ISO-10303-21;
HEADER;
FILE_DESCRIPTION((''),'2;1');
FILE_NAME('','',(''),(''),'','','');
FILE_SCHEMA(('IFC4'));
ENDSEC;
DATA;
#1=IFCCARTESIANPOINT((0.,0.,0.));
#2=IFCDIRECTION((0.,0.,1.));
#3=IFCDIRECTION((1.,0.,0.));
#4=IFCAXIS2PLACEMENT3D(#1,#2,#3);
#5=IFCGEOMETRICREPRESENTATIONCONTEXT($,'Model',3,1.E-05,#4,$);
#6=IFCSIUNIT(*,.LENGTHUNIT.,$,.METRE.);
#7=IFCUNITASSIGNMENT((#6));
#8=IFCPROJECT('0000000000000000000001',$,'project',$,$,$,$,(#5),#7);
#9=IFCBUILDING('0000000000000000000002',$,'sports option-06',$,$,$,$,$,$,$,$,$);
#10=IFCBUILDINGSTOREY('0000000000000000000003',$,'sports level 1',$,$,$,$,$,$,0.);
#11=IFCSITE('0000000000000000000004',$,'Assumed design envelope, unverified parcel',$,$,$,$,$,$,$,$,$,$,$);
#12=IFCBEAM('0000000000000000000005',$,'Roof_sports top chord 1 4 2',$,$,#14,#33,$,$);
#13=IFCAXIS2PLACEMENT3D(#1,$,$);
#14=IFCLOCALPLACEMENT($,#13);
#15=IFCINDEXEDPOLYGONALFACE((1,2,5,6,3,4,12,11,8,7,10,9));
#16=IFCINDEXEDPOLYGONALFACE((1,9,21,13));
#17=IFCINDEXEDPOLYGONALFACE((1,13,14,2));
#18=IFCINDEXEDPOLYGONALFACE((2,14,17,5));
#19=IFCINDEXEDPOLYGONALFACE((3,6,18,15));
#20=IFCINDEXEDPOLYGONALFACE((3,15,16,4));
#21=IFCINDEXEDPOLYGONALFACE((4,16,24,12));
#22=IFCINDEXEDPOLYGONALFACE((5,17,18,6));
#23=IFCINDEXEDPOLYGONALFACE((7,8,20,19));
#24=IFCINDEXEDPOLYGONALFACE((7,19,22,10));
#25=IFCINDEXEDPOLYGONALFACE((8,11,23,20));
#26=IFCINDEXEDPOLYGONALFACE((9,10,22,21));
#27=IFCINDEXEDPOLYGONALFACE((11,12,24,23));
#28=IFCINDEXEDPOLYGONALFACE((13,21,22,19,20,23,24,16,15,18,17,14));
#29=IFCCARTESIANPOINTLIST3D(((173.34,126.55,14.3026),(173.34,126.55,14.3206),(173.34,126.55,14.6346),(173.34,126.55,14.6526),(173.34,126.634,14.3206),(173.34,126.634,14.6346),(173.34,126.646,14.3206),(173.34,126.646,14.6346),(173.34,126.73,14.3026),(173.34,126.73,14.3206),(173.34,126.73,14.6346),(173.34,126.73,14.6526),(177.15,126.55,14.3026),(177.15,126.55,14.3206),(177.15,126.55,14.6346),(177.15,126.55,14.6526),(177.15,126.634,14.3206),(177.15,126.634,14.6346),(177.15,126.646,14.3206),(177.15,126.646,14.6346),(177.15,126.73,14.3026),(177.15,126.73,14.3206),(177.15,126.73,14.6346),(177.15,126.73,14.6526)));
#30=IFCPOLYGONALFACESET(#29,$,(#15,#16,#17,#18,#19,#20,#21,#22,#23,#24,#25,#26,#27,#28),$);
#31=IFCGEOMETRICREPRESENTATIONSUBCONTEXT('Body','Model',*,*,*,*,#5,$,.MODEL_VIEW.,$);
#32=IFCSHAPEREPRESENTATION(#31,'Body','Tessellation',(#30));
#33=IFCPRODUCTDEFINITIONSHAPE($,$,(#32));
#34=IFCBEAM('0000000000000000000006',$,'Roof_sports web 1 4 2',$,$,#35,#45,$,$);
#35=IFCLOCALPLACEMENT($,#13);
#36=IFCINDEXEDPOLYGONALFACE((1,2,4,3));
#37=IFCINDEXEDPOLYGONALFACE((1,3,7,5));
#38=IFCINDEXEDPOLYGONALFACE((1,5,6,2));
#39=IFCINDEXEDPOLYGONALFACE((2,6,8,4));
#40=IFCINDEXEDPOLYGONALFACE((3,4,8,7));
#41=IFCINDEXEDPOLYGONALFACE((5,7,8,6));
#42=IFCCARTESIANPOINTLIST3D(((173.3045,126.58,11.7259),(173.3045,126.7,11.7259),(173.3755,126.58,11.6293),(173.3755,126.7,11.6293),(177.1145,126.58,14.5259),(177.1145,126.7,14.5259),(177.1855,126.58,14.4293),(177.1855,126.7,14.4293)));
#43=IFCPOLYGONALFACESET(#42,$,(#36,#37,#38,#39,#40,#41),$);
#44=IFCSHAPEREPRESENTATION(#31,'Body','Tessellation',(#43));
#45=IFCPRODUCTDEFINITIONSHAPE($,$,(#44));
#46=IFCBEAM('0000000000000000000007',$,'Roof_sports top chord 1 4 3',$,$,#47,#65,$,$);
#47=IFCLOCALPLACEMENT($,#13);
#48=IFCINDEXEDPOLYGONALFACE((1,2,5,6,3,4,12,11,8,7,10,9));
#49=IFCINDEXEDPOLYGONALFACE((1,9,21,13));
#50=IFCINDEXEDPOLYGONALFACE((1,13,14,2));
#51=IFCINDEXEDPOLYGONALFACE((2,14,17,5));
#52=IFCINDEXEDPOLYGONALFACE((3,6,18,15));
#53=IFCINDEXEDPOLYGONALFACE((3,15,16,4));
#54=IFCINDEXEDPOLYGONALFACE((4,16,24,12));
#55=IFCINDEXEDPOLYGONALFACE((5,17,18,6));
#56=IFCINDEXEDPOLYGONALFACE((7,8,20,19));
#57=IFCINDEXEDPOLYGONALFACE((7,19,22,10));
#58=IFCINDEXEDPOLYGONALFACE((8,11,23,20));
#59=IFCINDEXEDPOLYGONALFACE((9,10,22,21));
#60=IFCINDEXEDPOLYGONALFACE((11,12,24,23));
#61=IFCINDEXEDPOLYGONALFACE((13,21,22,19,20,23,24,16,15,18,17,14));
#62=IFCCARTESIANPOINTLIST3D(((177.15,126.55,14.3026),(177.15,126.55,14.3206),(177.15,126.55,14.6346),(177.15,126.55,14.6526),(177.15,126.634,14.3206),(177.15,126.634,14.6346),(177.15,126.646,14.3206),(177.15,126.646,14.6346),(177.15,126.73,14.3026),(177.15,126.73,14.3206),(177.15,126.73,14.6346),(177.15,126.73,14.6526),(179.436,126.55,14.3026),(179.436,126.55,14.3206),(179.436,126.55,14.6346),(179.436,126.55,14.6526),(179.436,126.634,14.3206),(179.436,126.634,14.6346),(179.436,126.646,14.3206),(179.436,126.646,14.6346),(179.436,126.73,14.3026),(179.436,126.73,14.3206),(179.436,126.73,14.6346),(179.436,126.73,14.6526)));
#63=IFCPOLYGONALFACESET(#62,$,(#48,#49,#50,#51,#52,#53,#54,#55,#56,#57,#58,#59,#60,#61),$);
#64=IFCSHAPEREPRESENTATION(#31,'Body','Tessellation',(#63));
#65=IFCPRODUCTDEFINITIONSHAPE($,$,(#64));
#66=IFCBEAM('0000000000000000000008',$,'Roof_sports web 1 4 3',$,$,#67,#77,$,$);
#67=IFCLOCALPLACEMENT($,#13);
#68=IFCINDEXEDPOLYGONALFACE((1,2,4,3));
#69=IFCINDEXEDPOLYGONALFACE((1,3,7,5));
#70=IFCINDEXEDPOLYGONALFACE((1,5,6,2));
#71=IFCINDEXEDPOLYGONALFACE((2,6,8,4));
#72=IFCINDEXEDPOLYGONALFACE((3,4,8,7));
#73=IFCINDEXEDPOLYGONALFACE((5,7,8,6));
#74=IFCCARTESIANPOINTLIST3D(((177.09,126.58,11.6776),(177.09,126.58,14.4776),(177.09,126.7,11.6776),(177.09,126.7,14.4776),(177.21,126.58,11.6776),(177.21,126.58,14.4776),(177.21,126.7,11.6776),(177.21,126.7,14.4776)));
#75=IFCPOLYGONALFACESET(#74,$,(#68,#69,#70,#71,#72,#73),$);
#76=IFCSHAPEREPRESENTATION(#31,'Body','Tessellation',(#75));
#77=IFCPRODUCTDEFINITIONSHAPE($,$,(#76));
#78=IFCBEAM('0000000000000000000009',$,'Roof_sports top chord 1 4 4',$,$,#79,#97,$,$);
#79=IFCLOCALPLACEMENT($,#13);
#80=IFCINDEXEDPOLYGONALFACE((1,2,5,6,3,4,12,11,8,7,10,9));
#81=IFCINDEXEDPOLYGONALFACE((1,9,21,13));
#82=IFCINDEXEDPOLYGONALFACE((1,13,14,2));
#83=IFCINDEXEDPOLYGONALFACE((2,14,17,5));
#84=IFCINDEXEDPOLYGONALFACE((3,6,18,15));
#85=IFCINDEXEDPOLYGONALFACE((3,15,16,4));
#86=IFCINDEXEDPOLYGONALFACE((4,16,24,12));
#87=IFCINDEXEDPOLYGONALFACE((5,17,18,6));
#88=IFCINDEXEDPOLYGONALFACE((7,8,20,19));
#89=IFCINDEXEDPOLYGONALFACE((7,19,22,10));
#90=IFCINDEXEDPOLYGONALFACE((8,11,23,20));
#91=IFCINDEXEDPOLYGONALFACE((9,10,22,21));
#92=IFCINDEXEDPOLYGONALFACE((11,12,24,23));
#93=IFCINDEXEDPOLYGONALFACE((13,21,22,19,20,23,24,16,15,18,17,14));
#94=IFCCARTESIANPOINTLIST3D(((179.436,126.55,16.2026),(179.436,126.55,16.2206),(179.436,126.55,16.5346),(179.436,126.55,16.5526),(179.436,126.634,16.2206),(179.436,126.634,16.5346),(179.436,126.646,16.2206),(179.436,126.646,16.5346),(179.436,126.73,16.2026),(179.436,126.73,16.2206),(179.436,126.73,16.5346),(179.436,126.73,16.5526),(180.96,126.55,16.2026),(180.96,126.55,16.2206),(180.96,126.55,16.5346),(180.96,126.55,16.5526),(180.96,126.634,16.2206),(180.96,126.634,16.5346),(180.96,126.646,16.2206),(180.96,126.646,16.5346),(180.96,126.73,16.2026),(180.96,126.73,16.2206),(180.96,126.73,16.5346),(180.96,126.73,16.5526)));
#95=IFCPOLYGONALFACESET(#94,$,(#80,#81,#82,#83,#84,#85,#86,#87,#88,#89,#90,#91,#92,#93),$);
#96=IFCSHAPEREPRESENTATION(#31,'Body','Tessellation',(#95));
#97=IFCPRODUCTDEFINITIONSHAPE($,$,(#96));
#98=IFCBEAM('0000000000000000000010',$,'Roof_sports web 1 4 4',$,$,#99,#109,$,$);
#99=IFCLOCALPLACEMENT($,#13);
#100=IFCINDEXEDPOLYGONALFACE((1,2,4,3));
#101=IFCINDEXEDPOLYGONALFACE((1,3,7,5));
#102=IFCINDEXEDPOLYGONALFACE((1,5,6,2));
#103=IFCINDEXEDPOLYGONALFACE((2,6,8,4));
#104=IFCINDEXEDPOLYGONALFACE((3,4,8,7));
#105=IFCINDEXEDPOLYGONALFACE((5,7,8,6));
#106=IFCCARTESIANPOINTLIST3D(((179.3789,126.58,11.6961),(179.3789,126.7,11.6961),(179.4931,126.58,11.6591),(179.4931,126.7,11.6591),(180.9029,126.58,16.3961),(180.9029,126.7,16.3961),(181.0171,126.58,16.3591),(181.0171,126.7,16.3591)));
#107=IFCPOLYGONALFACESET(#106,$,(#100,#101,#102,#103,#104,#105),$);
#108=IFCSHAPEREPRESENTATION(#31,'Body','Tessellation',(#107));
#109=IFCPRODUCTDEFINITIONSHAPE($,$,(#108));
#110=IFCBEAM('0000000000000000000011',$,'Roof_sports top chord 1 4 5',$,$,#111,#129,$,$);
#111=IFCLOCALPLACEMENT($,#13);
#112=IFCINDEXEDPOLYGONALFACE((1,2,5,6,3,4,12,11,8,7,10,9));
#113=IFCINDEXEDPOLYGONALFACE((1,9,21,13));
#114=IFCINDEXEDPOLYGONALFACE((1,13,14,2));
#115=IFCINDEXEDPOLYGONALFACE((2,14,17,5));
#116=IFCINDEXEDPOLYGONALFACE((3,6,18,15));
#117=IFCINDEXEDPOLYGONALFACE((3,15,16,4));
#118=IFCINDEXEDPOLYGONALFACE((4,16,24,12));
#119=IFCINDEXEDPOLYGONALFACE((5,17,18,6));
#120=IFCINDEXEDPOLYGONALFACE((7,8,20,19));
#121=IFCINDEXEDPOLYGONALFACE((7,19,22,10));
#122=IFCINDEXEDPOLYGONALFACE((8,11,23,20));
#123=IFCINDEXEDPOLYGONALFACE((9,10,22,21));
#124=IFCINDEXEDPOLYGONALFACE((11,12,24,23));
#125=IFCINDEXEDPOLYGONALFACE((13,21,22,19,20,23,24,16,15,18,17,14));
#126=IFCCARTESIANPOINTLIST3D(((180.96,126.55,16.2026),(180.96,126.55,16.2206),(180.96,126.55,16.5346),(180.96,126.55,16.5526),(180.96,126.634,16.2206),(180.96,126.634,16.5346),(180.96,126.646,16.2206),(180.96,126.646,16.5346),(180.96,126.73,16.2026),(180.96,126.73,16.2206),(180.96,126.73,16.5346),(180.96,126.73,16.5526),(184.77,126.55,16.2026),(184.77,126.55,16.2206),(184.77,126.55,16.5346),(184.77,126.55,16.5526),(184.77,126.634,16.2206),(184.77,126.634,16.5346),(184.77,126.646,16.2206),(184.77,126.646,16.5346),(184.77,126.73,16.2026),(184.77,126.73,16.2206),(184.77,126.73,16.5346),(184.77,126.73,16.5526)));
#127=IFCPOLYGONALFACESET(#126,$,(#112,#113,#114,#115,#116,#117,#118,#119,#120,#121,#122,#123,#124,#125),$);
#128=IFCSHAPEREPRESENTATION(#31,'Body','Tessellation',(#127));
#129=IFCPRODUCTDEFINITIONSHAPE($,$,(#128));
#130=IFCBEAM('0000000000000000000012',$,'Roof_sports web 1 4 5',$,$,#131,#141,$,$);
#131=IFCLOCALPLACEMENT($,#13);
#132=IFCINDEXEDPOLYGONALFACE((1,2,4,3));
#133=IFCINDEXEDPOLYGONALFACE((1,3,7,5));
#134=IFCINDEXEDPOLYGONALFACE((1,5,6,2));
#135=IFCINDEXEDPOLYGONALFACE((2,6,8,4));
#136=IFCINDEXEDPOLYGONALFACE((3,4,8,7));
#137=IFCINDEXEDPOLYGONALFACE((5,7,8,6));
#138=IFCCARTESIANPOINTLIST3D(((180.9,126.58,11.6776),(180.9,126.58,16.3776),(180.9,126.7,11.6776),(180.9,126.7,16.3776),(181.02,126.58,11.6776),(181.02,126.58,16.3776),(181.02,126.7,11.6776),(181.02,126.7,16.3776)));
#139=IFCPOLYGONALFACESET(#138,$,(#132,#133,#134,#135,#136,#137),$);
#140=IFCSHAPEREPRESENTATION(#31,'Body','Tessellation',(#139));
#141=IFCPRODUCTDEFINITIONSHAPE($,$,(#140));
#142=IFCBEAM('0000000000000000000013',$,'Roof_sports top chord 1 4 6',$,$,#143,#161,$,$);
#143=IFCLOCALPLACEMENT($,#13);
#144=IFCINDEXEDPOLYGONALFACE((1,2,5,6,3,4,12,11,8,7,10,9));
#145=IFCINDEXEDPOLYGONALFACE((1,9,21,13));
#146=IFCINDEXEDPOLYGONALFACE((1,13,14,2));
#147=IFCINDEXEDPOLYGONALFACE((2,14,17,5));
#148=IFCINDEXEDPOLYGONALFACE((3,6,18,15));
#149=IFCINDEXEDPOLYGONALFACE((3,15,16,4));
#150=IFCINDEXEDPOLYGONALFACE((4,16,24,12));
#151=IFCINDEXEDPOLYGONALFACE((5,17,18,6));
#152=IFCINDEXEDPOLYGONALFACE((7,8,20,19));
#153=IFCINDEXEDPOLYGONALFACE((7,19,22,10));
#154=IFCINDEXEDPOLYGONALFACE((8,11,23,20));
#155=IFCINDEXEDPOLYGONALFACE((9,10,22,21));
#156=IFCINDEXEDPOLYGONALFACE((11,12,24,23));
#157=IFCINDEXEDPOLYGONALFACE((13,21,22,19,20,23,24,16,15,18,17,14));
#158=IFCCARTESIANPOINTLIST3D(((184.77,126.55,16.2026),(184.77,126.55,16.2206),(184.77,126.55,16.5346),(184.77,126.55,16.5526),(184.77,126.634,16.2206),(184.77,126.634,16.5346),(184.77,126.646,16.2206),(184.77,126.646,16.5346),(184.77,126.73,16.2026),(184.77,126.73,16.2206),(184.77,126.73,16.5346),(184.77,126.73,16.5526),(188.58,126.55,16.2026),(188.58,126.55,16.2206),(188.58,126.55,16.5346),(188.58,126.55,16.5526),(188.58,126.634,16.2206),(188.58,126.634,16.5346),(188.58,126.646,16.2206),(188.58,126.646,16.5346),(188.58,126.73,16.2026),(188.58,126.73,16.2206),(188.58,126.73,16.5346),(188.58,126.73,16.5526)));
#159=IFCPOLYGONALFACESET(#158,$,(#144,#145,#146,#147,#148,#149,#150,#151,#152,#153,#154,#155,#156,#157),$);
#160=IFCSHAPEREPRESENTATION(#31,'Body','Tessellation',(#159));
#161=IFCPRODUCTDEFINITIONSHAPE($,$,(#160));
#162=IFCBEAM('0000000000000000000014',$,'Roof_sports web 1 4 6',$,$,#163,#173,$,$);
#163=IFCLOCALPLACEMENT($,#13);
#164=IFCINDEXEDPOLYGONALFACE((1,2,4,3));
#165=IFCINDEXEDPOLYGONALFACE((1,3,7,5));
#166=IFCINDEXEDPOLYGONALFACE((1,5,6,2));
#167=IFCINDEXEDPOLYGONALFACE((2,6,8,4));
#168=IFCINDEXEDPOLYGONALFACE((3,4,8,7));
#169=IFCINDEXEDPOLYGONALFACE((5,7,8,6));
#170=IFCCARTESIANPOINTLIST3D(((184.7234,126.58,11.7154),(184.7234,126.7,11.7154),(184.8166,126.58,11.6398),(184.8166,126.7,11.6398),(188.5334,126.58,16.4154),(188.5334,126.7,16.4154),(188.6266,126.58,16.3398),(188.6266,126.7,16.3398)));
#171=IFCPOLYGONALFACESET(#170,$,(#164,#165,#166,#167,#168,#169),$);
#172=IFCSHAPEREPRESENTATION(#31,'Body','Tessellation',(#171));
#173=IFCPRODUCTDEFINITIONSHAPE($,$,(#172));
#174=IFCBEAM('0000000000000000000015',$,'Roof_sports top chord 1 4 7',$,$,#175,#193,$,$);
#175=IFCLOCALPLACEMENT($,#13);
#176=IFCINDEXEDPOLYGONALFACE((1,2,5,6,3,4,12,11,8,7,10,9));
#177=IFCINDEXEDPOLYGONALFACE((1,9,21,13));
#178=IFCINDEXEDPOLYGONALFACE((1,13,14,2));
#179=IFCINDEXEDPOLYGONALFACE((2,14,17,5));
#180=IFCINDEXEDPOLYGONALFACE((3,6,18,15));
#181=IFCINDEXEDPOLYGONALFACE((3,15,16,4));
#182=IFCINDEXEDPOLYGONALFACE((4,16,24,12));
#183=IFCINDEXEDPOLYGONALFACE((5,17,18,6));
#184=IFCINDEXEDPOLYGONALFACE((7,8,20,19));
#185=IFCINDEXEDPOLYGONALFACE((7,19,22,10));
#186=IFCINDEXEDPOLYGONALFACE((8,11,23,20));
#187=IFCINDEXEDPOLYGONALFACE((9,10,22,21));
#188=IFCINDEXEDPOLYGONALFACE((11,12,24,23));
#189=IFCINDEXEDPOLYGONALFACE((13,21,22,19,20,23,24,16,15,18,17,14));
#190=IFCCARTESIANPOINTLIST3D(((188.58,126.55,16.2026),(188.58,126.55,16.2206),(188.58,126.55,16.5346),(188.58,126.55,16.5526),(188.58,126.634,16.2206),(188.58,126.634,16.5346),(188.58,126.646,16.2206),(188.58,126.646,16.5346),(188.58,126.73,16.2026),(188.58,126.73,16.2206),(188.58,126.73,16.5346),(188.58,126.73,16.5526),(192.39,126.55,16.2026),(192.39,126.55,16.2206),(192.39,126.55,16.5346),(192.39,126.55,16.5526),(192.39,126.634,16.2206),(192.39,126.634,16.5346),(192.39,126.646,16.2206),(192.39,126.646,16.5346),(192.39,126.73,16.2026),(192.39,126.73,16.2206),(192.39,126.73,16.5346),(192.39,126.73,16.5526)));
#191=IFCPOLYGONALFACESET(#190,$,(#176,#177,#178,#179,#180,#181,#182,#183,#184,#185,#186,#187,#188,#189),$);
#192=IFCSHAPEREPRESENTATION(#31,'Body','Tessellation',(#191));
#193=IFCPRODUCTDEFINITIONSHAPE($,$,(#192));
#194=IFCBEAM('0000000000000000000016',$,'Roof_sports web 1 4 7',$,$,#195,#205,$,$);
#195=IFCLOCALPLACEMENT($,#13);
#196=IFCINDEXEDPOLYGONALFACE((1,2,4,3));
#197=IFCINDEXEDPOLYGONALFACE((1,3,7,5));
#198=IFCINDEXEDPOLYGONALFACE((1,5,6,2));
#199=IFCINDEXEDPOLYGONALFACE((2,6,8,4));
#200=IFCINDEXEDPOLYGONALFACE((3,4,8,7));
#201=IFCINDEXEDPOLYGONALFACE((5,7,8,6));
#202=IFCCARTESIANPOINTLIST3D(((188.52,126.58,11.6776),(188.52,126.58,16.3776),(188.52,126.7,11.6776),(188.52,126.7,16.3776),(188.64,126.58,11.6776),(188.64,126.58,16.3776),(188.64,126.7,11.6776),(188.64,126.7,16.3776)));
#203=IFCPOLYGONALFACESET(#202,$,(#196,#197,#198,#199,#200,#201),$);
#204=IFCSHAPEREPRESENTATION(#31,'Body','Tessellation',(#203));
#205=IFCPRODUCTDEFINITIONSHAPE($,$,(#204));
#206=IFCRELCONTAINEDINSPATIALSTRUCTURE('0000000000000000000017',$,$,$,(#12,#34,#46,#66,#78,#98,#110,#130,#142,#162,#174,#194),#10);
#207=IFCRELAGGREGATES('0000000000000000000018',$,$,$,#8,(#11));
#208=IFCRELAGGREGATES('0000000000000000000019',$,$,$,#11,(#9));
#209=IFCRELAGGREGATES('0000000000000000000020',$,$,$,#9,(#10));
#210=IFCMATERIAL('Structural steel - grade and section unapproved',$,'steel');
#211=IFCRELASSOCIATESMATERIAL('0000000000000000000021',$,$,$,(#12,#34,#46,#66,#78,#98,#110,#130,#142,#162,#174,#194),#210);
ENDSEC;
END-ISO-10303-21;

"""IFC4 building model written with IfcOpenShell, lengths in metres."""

from ifc_helpers import new_model, si_unit, frame, origin_with_axes, place, context, subcontext, project, spatial, rectangle, i_section, extrude, material, element, save


model = new_model("IFC4")

# Units and contexts
model_context = context("Model", 3, precision=1e-05, world=origin_with_axes())
body_context = subcontext(model_context, "Body", "Model", "MODEL_VIEW")
ifc_project = project(units=[si_unit("LENGTHUNIT", "METRE")], contexts=[model_context])

# Site, building, storey
site = spatial("IfcSite", under=ifc_project, Name="Assumed design envelope, unverified parcel")
building = spatial("IfcBuilding", under=site, Name="sports option-06")
storey = spatial("IfcBuildingStorey", under=building, Name="sports level 1", Elevation=0.0)

# Shared definitions
ifc_material_1 = material(Name="Structural steel - grade and section unapproved", Category="steel")

# Beams
beam_1_placement = place(None, frame((173.34, 126.64, 14.4776), z_axis=(1.0, 0.0, 0.0), x_axis=(0.0, 1.0, 0.0)))
element("IfcBeam", 1, at=beam_1_placement, inside=storey, material=ifc_material_1, Name="Roof_sports top chord 1 4 2", context=body_context, shape_type="SweptSolid", body=[
    extrude(i_section(OverallWidth=0.18, OverallDepth=0.35, WebThickness=0.012, FlangeThickness=0.018, FilletRadius=0.0), origin_with_axes(), (0.0, 0.0, 1.0), 3.81),
])
beam_2_placement = place(None, frame((173.34, 126.64, 11.6776), z_axis=(0.805799, 0.0, 0.592189), x_axis=(0.0, 1.0, 0.0)))
element("IfcBeam", 2, at=beam_2_placement, inside=storey, material=ifc_material_1, Name="Roof_sports web 1 4 2", context=body_context, shape_type="SweptSolid", body=[
    extrude(rectangle(XDim=0.12, YDim=0.12), origin_with_axes(), (0.0, 0.0, 1.0), 4.7282),
])
beam_3_placement = place(None, frame((177.15, 126.64, 14.4776), z_axis=(1.0, 0.0, 0.0), x_axis=(0.0, 1.0, 0.0)))
element("IfcBeam", 3, at=beam_3_placement, inside=storey, material=ifc_material_1, Name="Roof_sports top chord 1 4 3", context=body_context, shape_type="SweptSolid", body=[
    extrude(i_section(OverallWidth=0.18, OverallDepth=0.35, WebThickness=0.012, FlangeThickness=0.018, FilletRadius=0.0), origin_with_axes(), (0.0, 0.0, 1.0), 2.286),
])
beam_4_placement = place(None, frame((177.15, 126.64, 11.6776), z_axis=(0.0, 0.0, 1.0), x_axis=(-1.0, 0.0, 0.0)))
element("IfcBeam", 4, at=beam_4_placement, inside=storey, material=ifc_material_1, Name="Roof_sports web 1 4 3", context=body_context, shape_type="SweptSolid", body=[
    extrude(rectangle(XDim=0.12, YDim=0.12), origin_with_axes(), (0.0, 0.0, 1.0), 2.8),
])
beam_5_placement = place(None, frame((179.436, 126.64, 16.3776), z_axis=(1.0, 0.0, 0.0), x_axis=(0.0, 1.0, 0.0)))
element("IfcBeam", 5, at=beam_5_placement, inside=storey, material=ifc_material_1, Name="Roof_sports top chord 1 4 4", context=body_context, shape_type="SweptSolid", body=[
    extrude(i_section(OverallWidth=0.18, OverallDepth=0.35, WebThickness=0.012, FlangeThickness=0.018, FilletRadius=0.0), origin_with_axes(), (0.0, 0.0, 1.0), 1.524),
])
beam_6_placement = place(None, frame((179.436, 126.64, 11.6776), z_axis=(0.308446, 0.0, 0.951242), x_axis=(0.0, 1.0, 0.0)))
element("IfcBeam", 6, at=beam_6_placement, inside=storey, material=ifc_material_1, Name="Roof_sports web 1 4 4", context=body_context, shape_type="SweptSolid", body=[
    extrude(rectangle(XDim=0.12, YDim=0.12), origin_with_axes(), (0.0, 0.0, 1.0), 4.9409),
])
beam_7_placement = place(None, frame((180.96, 126.64, 16.3776), z_axis=(1.0, 0.0, 0.0), x_axis=(0.0, 1.0, 0.0)))
element("IfcBeam", 7, at=beam_7_placement, inside=storey, material=ifc_material_1, Name="Roof_sports top chord 1 4 5", context=body_context, shape_type="SweptSolid", body=[
    extrude(i_section(OverallWidth=0.18, OverallDepth=0.35, WebThickness=0.012, FlangeThickness=0.018, FilletRadius=0.0), origin_with_axes(), (0.0, 0.0, 1.0), 3.81),
])
beam_8_placement = place(None, frame((180.96, 126.64, 11.6776), z_axis=(0.0, 0.0, 1.0), x_axis=(-1.0, 0.0, 0.0)))
element("IfcBeam", 8, at=beam_8_placement, inside=storey, material=ifc_material_1, Name="Roof_sports web 1 4 5", context=body_context, shape_type="SweptSolid", body=[
    extrude(rectangle(XDim=0.12, YDim=0.12), origin_with_axes(), (0.0, 0.0, 1.0), 4.7),
])
beam_9_placement = place(None, frame((184.77, 126.64, 16.3776), z_axis=(1.0, 0.0, 0.0), x_axis=(0.0, 1.0, 0.0)))
element("IfcBeam", 9, at=beam_9_placement, inside=storey, material=ifc_material_1, Name="Roof_sports top chord 1 4 6", context=body_context, shape_type="SweptSolid", body=[
    extrude(i_section(OverallWidth=0.18, OverallDepth=0.35, WebThickness=0.012, FlangeThickness=0.018, FilletRadius=0.0), origin_with_axes(), (0.0, 0.0, 1.0), 3.81),
])
beam_10_placement = place(None, frame((184.77, 126.64, 11.6776), z_axis=(0.629721, 0.0, 0.776821), x_axis=(0.0, 1.0, 0.0)))
element("IfcBeam", 10, at=beam_10_placement, inside=storey, material=ifc_material_1, Name="Roof_sports web 1 4 6", context=body_context, shape_type="SweptSolid", body=[
    extrude(rectangle(XDim=0.12, YDim=0.12), origin_with_axes(), (0.0, 0.0, 1.0), 6.0503),
])
beam_11_placement = place(None, frame((188.58, 126.64, 16.3776), z_axis=(1.0, 0.0, 0.0), x_axis=(0.0, 1.0, 0.0)))
element("IfcBeam", 11, at=beam_11_placement, inside=storey, material=ifc_material_1, Name="Roof_sports top chord 1 4 7", context=body_context, shape_type="SweptSolid", body=[
    extrude(i_section(OverallWidth=0.18, OverallDepth=0.35, WebThickness=0.012, FlangeThickness=0.018, FilletRadius=0.0), origin_with_axes(), (0.0, 0.0, 1.0), 3.81),
])
beam_12_placement = place(None, frame((188.58, 126.64, 11.6776), z_axis=(0.0, 0.0, 1.0), x_axis=(-1.0, 0.0, 0.0)))
element("IfcBeam", 12, at=beam_12_placement, inside=storey, material=ifc_material_1, Name="Roof_sports web 1 4 7", context=body_context, shape_type="SweptSolid", body=[
    extrude(rectangle(XDim=0.12, YDim=0.12), origin_with_axes(), (0.0, 0.0, 1.0), 4.7),
])

save(model, "model.ifc")
